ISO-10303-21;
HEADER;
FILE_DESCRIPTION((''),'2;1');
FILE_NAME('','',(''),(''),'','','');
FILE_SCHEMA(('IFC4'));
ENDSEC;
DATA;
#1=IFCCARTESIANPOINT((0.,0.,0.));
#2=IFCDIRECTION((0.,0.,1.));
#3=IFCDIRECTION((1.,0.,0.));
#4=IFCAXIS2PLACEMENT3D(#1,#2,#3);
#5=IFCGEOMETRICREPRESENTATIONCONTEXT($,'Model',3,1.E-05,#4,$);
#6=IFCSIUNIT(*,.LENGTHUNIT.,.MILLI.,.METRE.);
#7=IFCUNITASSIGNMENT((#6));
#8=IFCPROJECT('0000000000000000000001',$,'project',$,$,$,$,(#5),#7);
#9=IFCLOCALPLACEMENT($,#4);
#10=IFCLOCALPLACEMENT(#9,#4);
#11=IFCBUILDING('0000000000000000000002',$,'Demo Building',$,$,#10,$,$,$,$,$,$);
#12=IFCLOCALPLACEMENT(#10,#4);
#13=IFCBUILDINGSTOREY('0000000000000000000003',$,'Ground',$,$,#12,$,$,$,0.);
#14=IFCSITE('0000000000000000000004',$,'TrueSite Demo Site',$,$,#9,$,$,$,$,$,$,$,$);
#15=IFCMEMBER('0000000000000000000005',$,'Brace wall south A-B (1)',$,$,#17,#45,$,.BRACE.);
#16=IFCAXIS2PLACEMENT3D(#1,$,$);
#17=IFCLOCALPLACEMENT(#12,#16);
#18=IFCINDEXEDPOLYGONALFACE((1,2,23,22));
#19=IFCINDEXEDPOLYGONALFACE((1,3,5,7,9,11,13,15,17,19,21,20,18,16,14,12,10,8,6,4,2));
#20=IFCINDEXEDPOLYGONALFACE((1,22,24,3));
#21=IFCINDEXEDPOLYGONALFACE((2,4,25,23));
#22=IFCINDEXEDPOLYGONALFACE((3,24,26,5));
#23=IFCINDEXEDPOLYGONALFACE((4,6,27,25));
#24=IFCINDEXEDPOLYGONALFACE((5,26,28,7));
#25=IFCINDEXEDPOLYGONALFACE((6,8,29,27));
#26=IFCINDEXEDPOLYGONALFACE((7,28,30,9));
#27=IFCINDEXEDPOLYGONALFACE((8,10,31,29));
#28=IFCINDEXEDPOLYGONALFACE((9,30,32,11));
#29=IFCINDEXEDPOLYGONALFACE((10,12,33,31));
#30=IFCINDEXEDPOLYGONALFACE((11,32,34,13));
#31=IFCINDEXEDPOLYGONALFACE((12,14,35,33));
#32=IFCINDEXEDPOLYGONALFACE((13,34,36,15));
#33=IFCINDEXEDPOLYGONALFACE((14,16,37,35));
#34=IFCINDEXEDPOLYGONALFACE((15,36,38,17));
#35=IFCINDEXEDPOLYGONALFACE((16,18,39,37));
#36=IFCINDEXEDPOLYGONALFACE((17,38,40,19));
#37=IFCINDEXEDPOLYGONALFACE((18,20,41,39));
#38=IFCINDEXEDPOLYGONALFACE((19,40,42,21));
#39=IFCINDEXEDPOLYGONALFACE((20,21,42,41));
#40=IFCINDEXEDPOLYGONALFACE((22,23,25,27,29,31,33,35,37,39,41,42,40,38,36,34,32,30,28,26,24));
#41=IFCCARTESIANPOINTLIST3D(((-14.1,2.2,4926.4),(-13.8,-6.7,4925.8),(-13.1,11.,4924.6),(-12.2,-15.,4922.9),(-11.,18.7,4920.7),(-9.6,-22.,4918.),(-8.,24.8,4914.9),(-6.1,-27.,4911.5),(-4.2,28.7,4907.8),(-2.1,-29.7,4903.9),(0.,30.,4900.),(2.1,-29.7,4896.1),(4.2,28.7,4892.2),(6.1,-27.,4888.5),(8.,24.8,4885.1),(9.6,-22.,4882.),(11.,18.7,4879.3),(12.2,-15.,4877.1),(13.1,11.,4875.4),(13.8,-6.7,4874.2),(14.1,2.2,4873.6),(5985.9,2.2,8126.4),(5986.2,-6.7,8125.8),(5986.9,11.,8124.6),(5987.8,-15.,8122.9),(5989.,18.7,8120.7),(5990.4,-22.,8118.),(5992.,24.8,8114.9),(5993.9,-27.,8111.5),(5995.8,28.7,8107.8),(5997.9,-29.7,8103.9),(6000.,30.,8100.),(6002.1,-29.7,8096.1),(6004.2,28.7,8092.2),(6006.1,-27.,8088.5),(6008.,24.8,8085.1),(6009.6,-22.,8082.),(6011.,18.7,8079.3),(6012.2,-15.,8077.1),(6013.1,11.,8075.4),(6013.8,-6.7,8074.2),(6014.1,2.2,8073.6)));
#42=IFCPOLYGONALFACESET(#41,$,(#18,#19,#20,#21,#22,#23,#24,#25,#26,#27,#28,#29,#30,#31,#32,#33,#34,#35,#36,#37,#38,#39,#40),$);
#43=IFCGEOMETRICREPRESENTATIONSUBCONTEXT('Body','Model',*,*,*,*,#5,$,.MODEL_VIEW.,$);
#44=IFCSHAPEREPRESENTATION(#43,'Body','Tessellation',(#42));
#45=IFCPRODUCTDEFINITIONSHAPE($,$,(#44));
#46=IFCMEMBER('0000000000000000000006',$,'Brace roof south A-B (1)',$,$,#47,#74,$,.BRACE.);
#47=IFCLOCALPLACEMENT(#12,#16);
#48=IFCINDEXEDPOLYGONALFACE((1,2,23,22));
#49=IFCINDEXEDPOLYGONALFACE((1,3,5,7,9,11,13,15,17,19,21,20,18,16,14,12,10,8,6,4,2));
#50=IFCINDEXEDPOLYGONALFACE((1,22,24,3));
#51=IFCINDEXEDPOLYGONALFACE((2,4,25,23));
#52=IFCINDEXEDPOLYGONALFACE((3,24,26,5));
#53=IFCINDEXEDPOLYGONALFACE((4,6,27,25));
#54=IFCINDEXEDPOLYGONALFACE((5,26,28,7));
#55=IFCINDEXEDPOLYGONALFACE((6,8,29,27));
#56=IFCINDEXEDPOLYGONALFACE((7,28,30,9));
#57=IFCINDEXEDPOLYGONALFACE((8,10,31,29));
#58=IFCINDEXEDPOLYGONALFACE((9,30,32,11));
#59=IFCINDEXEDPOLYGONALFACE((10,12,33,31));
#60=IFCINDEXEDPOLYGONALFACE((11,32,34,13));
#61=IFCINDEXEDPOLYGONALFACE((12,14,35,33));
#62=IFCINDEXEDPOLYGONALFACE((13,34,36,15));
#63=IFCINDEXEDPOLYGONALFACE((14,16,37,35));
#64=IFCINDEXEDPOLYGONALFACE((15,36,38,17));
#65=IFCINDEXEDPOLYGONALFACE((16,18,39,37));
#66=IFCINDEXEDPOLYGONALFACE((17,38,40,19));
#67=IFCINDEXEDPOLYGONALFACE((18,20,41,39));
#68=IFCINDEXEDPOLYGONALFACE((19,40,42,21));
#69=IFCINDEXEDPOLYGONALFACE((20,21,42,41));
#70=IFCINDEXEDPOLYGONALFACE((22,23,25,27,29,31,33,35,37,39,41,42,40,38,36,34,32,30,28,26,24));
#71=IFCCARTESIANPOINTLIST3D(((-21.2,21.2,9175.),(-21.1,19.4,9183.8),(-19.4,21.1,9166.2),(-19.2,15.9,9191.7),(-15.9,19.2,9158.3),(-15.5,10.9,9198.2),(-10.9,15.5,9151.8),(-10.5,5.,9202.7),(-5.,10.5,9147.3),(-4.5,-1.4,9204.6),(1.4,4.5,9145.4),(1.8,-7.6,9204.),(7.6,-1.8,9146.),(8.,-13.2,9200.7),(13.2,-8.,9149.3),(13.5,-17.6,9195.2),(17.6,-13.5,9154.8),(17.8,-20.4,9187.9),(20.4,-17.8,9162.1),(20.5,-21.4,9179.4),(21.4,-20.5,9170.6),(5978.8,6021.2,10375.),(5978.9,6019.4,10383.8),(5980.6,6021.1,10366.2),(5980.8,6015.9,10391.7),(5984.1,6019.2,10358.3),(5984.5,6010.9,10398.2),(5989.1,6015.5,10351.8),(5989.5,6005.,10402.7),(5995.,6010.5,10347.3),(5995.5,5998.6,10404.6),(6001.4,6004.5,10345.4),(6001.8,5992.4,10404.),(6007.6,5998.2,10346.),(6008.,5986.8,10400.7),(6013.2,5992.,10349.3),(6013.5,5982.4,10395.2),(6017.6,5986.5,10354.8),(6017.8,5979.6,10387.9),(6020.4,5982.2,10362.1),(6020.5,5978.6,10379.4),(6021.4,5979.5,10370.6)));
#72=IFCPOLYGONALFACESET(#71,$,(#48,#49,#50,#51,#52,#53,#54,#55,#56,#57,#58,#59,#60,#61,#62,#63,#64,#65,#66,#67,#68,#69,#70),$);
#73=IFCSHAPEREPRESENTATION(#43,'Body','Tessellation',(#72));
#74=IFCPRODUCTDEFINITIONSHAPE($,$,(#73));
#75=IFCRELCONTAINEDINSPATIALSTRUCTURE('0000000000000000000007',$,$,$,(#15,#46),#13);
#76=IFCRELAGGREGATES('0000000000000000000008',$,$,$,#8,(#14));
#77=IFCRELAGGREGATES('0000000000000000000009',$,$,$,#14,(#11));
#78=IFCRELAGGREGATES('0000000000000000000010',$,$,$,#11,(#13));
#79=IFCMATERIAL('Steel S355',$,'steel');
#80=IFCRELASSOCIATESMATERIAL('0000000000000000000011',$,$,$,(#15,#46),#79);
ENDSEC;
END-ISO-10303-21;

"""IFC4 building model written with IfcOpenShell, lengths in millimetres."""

from ifc_helpers import new_model, si_unit, frame, origin_with_axes, place, context, subcontext, project, spatial, circle, extrude, material, element, save


model = new_model("IFC4")

# Units and contexts
model_context = context("Model", 3, precision=1e-05, world=origin_with_axes())
body_context = subcontext(model_context, "Body", "Model", "MODEL_VIEW")
ifc_project = project(units=[si_unit("LENGTHUNIT", "METRE", prefix="MILLI")], contexts=[model_context])

# Site, building, storey
site_placement = place(None, origin_with_axes())
site = spatial("IfcSite", under=ifc_project, at=site_placement, Name="TrueSite Demo Site")
building_placement = place(site_placement, origin_with_axes())
building = spatial("IfcBuilding", under=site, at=building_placement, Name="Demo Building")
storey_placement = place(building_placement, origin_with_axes())
storey = spatial("IfcBuildingStorey", under=building, at=storey_placement, Name="Ground", Elevation=0.0)

# Shared definitions
ifc_material_1 = material(Name="Steel S355", Category="steel")

# Members
member_1_placement = place(storey_placement, frame((0.0, 0.0, 4900.0), z_axis=(0.882353, 0.0, 0.470588), x_axis=(0.0, 1.0, 0.0)))
element("IfcMember", 1, at=member_1_placement, inside=storey, material=ifc_material_1, Name="Brace wall south A-B (1)", PredefinedType="BRACE", context=body_context, shape_type="SweptSolid", body=[
    extrude(circle(Radius=30.0), origin_with_axes(), (0.0, 0.0, 1.0), 6800.0),
])
member_2_placement = place(storey_placement, frame((0.0, 0.0, 9175.0), z_axis=(0.70014, 0.70014, 0.140028), x_axis=(-0.707107, 0.707107, 0.0)))
element("IfcMember", 2, at=member_2_placement, inside=storey, material=ifc_material_1, Name="Brace roof south A-B (1)", PredefinedType="BRACE", context=body_context, shape_type="SweptSolid", body=[
    extrude(circle(Radius=30.0), origin_with_axes(), (0.0, 0.0, 1.0), 8569.7),
])

save(model, "model.ifc")
